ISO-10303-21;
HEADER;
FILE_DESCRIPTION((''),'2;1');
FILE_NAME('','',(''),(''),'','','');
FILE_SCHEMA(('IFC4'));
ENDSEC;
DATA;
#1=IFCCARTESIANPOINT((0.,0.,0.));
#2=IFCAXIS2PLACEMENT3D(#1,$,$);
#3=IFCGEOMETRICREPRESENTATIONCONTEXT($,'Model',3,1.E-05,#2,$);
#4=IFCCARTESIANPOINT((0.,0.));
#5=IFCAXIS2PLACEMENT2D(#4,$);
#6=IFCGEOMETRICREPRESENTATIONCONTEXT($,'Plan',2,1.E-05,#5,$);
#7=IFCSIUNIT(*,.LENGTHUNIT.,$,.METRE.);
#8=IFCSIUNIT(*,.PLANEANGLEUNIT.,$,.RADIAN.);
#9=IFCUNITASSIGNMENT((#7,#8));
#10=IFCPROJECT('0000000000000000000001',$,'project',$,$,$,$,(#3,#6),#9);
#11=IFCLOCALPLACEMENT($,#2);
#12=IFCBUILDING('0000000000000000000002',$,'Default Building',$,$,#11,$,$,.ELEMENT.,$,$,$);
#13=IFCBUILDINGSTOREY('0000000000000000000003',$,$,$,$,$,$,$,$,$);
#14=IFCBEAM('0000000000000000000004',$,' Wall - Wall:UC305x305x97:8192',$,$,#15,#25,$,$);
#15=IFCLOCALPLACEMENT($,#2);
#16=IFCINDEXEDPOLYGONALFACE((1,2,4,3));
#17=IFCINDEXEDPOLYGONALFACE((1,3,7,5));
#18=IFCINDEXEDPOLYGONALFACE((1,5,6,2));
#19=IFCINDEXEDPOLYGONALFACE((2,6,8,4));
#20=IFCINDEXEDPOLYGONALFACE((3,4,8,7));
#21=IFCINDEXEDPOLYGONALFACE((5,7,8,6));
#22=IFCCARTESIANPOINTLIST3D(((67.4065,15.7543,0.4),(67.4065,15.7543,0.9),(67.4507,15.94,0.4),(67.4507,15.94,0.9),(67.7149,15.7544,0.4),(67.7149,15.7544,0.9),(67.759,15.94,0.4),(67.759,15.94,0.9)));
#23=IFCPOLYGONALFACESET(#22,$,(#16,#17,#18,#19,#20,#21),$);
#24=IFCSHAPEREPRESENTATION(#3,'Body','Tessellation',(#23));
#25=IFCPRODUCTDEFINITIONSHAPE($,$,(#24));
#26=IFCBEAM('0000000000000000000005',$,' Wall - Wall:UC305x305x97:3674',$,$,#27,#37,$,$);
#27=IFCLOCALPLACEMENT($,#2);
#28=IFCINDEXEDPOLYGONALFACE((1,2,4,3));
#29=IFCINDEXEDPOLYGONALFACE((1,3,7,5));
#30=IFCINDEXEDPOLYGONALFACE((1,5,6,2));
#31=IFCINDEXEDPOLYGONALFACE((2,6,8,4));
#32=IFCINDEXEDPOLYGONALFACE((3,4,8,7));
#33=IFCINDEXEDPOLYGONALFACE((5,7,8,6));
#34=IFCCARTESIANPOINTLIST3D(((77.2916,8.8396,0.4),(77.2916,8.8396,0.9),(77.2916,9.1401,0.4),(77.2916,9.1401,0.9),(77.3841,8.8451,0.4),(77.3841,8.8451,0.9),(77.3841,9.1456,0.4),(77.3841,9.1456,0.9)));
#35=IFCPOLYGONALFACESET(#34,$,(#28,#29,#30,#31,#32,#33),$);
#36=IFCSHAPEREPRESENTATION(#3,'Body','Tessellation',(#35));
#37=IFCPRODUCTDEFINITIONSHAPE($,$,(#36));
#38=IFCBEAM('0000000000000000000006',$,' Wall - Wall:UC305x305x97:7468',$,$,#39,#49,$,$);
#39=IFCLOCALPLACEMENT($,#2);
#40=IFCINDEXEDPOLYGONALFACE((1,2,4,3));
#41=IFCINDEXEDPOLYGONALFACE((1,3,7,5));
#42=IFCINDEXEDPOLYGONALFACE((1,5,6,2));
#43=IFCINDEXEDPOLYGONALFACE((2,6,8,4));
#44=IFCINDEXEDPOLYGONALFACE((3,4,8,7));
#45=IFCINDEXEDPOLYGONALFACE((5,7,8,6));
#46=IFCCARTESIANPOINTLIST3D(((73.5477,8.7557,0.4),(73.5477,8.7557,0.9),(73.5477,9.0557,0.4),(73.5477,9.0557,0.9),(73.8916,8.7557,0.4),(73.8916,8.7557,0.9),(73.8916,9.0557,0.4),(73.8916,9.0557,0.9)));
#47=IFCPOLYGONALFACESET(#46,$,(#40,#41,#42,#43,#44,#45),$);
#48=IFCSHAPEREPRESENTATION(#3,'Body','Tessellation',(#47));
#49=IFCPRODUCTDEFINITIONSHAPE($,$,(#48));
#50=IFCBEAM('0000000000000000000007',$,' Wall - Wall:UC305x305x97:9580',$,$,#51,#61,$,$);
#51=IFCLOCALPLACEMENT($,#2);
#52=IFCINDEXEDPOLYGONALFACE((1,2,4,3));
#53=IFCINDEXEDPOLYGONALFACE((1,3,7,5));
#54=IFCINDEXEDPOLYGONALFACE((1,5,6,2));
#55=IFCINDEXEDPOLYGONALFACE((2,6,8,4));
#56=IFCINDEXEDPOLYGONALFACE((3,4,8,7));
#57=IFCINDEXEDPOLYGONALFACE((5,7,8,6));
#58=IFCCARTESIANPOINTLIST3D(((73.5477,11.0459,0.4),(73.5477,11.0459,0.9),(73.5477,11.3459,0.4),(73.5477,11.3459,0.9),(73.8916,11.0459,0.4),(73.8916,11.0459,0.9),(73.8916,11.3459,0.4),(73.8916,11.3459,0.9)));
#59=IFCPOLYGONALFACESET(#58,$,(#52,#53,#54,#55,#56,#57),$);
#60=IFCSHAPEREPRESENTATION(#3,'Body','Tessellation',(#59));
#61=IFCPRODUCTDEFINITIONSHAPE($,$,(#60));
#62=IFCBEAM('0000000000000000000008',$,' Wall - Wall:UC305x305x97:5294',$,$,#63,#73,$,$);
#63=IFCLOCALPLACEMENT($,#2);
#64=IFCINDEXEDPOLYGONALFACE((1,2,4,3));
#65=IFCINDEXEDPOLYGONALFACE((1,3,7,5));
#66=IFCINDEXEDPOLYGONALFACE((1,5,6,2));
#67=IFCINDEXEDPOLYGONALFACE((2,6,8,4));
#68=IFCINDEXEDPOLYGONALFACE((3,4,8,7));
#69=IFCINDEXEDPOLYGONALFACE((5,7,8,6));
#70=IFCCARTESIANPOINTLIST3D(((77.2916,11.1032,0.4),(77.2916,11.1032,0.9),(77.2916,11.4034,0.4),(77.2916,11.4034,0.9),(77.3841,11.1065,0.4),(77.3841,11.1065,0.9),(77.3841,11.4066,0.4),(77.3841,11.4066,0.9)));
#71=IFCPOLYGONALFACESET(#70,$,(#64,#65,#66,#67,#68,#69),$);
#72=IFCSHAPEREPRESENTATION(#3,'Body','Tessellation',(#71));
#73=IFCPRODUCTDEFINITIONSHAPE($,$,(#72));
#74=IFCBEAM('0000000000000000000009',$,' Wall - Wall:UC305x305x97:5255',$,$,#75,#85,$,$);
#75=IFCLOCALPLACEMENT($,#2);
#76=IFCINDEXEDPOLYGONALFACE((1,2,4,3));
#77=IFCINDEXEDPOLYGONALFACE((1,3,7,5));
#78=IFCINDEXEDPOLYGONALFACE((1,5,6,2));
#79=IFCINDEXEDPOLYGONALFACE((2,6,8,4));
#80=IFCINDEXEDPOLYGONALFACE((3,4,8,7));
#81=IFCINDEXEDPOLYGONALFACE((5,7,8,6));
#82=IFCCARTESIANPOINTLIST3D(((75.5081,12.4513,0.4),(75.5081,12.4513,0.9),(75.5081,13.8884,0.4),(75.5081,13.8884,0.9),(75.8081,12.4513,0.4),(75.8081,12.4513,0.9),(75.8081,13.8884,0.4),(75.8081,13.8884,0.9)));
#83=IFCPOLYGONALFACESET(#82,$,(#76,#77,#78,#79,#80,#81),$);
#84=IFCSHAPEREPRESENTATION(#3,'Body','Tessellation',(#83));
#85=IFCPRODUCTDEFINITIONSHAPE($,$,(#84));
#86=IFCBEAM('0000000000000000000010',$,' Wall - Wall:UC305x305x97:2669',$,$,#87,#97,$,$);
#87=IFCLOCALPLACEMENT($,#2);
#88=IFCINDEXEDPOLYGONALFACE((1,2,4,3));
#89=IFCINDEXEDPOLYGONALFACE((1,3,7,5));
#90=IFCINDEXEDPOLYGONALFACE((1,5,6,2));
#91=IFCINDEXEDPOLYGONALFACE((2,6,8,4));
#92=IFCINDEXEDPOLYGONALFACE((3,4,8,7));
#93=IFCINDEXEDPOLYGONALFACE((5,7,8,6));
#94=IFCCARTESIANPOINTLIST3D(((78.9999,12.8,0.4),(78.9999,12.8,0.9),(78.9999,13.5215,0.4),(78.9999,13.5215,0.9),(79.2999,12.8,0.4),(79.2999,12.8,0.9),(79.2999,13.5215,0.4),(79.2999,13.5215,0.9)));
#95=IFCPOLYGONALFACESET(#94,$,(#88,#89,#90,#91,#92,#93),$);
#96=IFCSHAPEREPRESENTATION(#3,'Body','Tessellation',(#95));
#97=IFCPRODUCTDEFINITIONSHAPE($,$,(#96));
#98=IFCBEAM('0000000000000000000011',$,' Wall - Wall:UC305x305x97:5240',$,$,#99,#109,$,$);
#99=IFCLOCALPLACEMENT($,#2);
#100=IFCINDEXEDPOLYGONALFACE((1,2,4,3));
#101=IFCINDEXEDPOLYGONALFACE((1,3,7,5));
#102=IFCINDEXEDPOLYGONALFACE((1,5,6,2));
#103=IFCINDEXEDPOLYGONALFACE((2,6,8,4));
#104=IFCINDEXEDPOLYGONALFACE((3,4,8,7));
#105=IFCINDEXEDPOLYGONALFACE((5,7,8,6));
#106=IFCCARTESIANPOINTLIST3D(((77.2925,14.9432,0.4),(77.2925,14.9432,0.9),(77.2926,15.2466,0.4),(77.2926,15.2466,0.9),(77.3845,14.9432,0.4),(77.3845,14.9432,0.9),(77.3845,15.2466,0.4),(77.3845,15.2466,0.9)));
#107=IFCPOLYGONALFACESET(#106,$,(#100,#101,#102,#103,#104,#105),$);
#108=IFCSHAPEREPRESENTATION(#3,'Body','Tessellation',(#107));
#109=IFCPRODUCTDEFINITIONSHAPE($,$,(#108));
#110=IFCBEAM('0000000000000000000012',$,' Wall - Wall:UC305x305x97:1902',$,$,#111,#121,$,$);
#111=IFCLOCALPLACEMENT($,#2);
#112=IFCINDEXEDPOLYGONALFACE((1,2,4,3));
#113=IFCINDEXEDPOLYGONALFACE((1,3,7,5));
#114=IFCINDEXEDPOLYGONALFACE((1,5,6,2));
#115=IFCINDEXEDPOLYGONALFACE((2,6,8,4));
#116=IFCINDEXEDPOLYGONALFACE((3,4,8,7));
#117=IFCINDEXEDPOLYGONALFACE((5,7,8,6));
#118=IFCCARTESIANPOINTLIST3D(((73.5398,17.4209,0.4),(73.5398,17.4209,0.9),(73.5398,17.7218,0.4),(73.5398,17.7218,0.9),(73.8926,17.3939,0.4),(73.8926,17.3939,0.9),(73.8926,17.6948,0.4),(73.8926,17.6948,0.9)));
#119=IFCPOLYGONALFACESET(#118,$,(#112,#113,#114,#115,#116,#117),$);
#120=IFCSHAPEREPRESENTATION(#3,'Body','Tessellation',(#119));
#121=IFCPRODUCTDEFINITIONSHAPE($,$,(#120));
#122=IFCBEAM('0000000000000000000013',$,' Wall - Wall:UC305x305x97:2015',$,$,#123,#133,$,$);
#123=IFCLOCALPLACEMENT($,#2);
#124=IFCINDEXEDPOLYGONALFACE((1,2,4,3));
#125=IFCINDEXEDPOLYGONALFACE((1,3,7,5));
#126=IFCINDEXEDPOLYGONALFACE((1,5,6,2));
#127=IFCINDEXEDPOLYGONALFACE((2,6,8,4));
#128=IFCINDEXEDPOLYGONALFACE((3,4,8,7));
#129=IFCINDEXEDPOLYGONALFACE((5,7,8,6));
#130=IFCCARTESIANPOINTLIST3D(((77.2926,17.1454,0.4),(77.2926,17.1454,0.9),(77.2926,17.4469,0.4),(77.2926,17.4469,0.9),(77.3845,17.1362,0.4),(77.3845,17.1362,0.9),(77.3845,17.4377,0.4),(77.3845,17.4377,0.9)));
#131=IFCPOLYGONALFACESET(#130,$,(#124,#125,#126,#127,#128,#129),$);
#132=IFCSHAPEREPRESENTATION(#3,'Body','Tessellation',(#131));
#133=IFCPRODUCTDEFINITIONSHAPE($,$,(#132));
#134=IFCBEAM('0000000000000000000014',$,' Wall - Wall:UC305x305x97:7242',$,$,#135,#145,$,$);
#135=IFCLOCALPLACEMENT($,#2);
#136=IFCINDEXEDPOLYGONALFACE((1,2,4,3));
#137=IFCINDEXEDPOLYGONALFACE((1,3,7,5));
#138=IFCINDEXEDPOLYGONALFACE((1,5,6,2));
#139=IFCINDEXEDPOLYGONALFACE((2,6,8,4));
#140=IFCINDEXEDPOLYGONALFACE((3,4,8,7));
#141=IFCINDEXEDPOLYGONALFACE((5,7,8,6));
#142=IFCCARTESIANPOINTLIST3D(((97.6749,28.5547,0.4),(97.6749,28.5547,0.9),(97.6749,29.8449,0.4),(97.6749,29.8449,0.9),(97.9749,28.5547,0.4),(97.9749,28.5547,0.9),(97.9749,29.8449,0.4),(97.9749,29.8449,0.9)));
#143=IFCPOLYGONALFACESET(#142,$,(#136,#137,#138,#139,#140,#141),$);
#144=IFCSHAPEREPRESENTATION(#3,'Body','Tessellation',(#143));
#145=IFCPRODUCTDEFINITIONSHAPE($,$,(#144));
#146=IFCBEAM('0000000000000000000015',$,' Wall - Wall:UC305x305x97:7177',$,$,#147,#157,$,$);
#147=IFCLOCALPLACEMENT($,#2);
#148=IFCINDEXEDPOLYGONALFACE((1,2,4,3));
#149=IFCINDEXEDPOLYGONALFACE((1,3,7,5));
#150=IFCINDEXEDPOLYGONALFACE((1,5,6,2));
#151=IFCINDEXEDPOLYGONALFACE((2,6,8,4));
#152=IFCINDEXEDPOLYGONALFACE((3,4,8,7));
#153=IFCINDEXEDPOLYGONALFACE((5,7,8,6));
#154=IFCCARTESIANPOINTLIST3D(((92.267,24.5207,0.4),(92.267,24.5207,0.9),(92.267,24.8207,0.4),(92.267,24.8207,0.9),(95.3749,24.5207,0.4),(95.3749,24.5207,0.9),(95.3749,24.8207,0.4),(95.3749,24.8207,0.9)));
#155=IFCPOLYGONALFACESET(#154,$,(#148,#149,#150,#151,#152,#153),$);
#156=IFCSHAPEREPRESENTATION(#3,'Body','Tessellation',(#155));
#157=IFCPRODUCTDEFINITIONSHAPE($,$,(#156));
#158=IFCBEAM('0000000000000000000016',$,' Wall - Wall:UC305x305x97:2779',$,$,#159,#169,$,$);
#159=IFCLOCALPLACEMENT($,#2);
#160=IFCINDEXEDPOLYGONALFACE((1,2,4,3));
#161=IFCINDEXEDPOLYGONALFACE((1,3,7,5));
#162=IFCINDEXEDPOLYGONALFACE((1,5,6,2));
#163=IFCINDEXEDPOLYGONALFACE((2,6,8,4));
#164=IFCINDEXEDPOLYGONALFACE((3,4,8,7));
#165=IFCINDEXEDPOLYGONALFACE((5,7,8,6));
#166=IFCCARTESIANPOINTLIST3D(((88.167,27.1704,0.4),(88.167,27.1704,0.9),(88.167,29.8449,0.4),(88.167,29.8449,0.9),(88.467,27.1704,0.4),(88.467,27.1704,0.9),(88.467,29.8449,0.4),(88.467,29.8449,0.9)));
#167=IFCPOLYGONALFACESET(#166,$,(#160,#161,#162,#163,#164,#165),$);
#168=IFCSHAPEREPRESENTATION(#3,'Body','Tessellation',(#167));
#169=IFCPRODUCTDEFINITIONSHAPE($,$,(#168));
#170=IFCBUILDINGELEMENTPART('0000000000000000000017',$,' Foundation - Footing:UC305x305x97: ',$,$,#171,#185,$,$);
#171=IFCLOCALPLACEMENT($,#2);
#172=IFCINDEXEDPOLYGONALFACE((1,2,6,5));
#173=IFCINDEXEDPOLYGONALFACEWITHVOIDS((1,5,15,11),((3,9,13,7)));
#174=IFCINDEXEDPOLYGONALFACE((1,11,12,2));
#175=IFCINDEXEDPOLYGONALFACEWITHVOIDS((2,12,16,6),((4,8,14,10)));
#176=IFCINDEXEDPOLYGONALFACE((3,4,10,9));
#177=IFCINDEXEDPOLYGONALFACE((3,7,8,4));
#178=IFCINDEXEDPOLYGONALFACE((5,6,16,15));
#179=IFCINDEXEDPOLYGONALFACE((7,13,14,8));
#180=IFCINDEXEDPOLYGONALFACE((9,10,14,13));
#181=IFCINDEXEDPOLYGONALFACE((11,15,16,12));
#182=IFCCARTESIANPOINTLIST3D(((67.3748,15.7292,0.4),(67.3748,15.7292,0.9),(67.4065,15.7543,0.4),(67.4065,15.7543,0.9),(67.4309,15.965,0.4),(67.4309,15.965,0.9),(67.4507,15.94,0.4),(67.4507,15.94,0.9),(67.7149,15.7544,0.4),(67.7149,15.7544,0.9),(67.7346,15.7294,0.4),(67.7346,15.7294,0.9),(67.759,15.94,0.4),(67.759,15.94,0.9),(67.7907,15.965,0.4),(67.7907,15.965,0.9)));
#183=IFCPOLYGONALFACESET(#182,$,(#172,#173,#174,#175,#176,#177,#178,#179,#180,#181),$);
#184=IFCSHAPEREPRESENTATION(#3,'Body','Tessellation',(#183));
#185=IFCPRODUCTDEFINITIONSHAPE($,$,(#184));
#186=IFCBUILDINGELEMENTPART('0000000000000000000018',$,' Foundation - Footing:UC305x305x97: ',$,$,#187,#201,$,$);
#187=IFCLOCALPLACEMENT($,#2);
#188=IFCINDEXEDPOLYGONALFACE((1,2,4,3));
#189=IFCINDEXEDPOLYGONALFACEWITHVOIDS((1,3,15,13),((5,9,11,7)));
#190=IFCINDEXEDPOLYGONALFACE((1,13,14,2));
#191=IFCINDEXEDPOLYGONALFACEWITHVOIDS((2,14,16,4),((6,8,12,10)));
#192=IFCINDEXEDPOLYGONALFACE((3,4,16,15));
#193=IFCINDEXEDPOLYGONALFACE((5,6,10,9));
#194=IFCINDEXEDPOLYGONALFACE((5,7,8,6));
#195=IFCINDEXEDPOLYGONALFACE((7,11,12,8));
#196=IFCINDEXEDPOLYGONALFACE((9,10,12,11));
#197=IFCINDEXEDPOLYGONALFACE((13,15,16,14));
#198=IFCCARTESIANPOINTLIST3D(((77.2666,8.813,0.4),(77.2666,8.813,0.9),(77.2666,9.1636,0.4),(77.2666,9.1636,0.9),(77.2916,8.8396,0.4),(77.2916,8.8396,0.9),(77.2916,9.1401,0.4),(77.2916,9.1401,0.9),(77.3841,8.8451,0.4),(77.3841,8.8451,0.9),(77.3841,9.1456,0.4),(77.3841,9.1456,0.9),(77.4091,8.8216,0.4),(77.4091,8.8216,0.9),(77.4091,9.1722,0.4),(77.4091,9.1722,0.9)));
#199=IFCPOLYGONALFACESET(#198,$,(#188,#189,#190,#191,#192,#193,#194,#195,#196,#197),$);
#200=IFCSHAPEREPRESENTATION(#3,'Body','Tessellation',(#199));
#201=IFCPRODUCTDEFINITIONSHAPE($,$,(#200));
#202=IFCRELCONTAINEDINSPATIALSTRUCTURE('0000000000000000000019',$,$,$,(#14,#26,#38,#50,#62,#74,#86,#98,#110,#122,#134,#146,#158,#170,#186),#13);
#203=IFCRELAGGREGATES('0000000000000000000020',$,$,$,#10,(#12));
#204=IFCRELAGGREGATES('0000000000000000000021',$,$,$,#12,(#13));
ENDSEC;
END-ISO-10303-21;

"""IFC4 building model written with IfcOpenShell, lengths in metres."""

from ifc_helpers import new_model, si_unit, origin, origin_2d, place, context, project, spatial, polyline, outline, extrude, element, save


model = new_model("IFC4")

# Units and contexts
model_context = context("Model", 3, precision=1e-05, world=origin())
plan_context = context("Plan", 2, precision=1e-05, world=origin_2d())
ifc_project = project(units=[si_unit("LENGTHUNIT", "METRE"), si_unit("PLANEANGLEUNIT", "RADIAN")], contexts=[model_context, plan_context])

# Building, storey
building_placement = place(None, origin())
building = spatial("IfcBuilding", under=ifc_project, at=building_placement, Name="Default Building", CompositionType="ELEMENT")
storey = spatial("IfcBuildingStorey", under=building)

# Beams
element("IfcBeam", 1, inside=storey, Name=" Wall - Wall:UC305x305x97:8192", context=model_context, shape_type="SweptSolid", body=[
    extrude(outline(polyline([(67.7149, 15.7544, 0.4), (67.759, 15.94, 0.4), (67.4507, 15.94, 0.4), (67.4065, 15.7543, 0.4), (67.7149, 15.7544, 0.4)])), None, (0.0, 0.0, 1.0), 0.5),
])
element("IfcBeam", 2, inside=storey, Name=" Wall - Wall:UC305x305x97:3674", context=model_context, shape_type="SweptSolid", body=[
    extrude(outline(polyline([(77.3841, 8.8451, 0.4), (77.2916, 8.8396, 0.4), (77.2916, 9.1401, 0.4), (77.3841, 9.1456, 0.4), (77.3841, 8.8451, 0.4)])), None, (0.0, 0.0, 1.0), 0.5),
])
element("IfcBeam", 3, inside=storey, Name=" Wall - Wall:UC305x305x97:7468", context=model_context, shape_type="SweptSolid", body=[
    extrude(outline(polyline([(73.8916, 8.7557, 0.4), (73.5477, 8.7557, 0.4), (73.5477, 9.0557, 0.4), (73.8916, 9.0557, 0.4), (73.8916, 8.7557, 0.4)])), None, (0.0, 0.0, 1.0), 0.5),
])
element("IfcBeam", 4, inside=storey, Name=" Wall - Wall:UC305x305x97:9580", context=model_context, shape_type="SweptSolid", body=[
    extrude(outline(polyline([(73.8916, 11.0459, 0.4), (73.5477, 11.0459, 0.4), (73.5477, 11.3459, 0.4), (73.8916, 11.3459, 0.4), (73.8916, 11.0459, 0.4)])), None, (0.0, 0.0, 1.0), 0.5),
])
element("IfcBeam", 5, inside=storey, Name=" Wall - Wall:UC305x305x97:5294", context=model_context, shape_type="SweptSolid", body=[
    extrude(outline(polyline([(77.3841, 11.1065, 0.4), (77.2916, 11.1032, 0.4), (77.2916, 11.4034, 0.4), (77.3841, 11.4066, 0.4), (77.3841, 11.1065, 0.4)])), None, (0.0, 0.0, 1.0), 0.5),
])
element("IfcBeam", 6, inside=storey, Name=" Wall - Wall:UC305x305x97:5255", context=model_context, shape_type="SweptSolid", body=[
    extrude(outline(polyline([(75.8081, 12.4513, 0.4), (75.5081, 12.4513, 0.4), (75.5081, 13.8884, 0.4), (75.8081, 13.8884, 0.4), (75.8081, 12.4513, 0.4)])), None, (0.0, 0.0, 1.0), 0.5),
])
element("IfcBeam", 7, inside=storey, Name=" Wall - Wall:UC305x305x97:2669", context=model_context, shape_type="SweptSolid", body=[
    extrude(outline(polyline([(79.2999, 12.8, 0.4), (78.9999, 12.8, 0.4), (78.9999, 13.5215, 0.4), (79.2999, 13.5215, 0.4), (79.2999, 12.8, 0.4)])), None, (0.0, 0.0, 1.0), 0.5),
])
element("IfcBeam", 8, inside=storey, Name=" Wall - Wall:UC305x305x97:5240", context=model_context, shape_type="SweptSolid", body=[
    extrude(outline(polyline([(77.3845, 14.9432, 0.4), (77.2925, 14.9432, 0.4), (77.2926, 15.2466, 0.4), (77.3845, 15.2466, 0.4), (77.3845, 14.9432, 0.4)])), None, (0.0, 0.0, 1.0), 0.5),
])
element("IfcBeam", 9, inside=storey, Name=" Wall - Wall:UC305x305x97:1902", context=model_context, shape_type="SweptSolid", body=[
    extrude(outline(polyline([(73.8926, 17.3939, 0.4), (73.5398, 17.4209, 0.4), (73.5398, 17.7218, 0.4), (73.8926, 17.6948, 0.4), (73.8926, 17.3939, 0.4)])), None, (0.0, 0.0, 1.0), 0.5),
])
element("IfcBeam", 10, inside=storey, Name=" Wall - Wall:UC305x305x97:2015", context=model_context, shape_type="SweptSolid", body=[
    extrude(outline(polyline([(77.3845, 17.1362, 0.4), (77.2926, 17.1454, 0.4), (77.2926, 17.4469, 0.4), (77.3845, 17.4377, 0.4), (77.3845, 17.1362, 0.4)])), None, (0.0, 0.0, 1.0), 0.5),
])
element("IfcBeam", 11, inside=storey, Name=" Wall - Wall:UC305x305x97:7242", context=model_context, shape_type="SweptSolid", body=[
    extrude(outline(polyline([(97.9749, 28.5547, 0.4), (97.6749, 28.5547, 0.4), (97.6749, 29.8449, 0.4), (97.9749, 29.8449, 0.4), (97.9749, 28.5547, 0.4)])), None, (0.0, 0.0, 1.0), 0.5),
])
element("IfcBeam", 12, inside=storey, Name=" Wall - Wall:UC305x305x97:7177", context=model_context, shape_type="SweptSolid", body=[
    extrude(outline(polyline([(95.3749, 24.5207, 0.4), (95.3749, 24.8207, 0.4), (92.267, 24.8207, 0.4), (92.267, 24.5207, 0.4), (95.3749, 24.5207, 0.4)])), None, (0.0, 0.0, 1.0), 0.5),
])
element("IfcBeam", 13, inside=storey, Name=" Wall - Wall:UC305x305x97:2779", context=model_context, shape_type="SweptSolid", body=[
    extrude(outline(polyline([(88.467, 27.1704, 0.4), (88.167, 27.1704, 0.4), (88.167, 29.8449, 0.4), (88.467, 29.8449, 0.4), (88.467, 27.1704, 0.4)])), None, (0.0, 0.0, 1.0), 0.5),
])

# Building element parts, openings
building_element_part_1 = element("IfcBuildingElementPart", 14, inside=storey, Name=" Foundation - Footing:UC305x305x97: ", context=model_context, shape_type="SweptSolid", body=[
    extrude(outline(polyline([(67.7346, 15.7294, 0.4), (67.7907, 15.965, 0.4), (67.4309, 15.965, 0.4), (67.3748, 15.7292, 0.4), (67.7346, 15.7294, 0.4)])), None, (0.0, 0.0, 1.0), 0.5),
])
element("IfcOpeningElement", 15, inside=storey, cuts=building_element_part_1, context=model_context, shape_type="SweptSolid", body=[
    extrude(outline(polyline([(67.7149, 15.7544, 0.4), (67.759, 15.94, 0.4), (67.4507, 15.94, 0.4), (67.4065, 15.7543, 0.4), (67.7149, 15.7544, 0.4)])), None, (0.0, 0.0, 1.0), 0.5),
])
building_element_part_2 = element("IfcBuildingElementPart", 16, inside=storey, Name=" Foundation - Footing:UC305x305x97: ", context=model_context, shape_type="SweptSolid", body=[
    extrude(outline(polyline([(77.4091, 8.8216, 0.4), (77.2666, 8.813, 0.4), (77.2666, 9.1636, 0.4), (77.4091, 9.1722, 0.4), (77.4091, 8.8216, 0.4)])), None, (0.0, 0.0, 1.0), 0.5),
])
element("IfcOpeningElement", 17, inside=storey, cuts=building_element_part_2, context=model_context, shape_type="SweptSolid", body=[
    extrude(outline(polyline([(77.3841, 8.8451, 0.4), (77.2916, 8.8396, 0.4), (77.2916, 9.1401, 0.4), (77.3841, 9.1456, 0.4), (77.3841, 8.8451, 0.4)])), None, (0.0, 0.0, 1.0), 0.5),
])

save(model, "model.ifc")
